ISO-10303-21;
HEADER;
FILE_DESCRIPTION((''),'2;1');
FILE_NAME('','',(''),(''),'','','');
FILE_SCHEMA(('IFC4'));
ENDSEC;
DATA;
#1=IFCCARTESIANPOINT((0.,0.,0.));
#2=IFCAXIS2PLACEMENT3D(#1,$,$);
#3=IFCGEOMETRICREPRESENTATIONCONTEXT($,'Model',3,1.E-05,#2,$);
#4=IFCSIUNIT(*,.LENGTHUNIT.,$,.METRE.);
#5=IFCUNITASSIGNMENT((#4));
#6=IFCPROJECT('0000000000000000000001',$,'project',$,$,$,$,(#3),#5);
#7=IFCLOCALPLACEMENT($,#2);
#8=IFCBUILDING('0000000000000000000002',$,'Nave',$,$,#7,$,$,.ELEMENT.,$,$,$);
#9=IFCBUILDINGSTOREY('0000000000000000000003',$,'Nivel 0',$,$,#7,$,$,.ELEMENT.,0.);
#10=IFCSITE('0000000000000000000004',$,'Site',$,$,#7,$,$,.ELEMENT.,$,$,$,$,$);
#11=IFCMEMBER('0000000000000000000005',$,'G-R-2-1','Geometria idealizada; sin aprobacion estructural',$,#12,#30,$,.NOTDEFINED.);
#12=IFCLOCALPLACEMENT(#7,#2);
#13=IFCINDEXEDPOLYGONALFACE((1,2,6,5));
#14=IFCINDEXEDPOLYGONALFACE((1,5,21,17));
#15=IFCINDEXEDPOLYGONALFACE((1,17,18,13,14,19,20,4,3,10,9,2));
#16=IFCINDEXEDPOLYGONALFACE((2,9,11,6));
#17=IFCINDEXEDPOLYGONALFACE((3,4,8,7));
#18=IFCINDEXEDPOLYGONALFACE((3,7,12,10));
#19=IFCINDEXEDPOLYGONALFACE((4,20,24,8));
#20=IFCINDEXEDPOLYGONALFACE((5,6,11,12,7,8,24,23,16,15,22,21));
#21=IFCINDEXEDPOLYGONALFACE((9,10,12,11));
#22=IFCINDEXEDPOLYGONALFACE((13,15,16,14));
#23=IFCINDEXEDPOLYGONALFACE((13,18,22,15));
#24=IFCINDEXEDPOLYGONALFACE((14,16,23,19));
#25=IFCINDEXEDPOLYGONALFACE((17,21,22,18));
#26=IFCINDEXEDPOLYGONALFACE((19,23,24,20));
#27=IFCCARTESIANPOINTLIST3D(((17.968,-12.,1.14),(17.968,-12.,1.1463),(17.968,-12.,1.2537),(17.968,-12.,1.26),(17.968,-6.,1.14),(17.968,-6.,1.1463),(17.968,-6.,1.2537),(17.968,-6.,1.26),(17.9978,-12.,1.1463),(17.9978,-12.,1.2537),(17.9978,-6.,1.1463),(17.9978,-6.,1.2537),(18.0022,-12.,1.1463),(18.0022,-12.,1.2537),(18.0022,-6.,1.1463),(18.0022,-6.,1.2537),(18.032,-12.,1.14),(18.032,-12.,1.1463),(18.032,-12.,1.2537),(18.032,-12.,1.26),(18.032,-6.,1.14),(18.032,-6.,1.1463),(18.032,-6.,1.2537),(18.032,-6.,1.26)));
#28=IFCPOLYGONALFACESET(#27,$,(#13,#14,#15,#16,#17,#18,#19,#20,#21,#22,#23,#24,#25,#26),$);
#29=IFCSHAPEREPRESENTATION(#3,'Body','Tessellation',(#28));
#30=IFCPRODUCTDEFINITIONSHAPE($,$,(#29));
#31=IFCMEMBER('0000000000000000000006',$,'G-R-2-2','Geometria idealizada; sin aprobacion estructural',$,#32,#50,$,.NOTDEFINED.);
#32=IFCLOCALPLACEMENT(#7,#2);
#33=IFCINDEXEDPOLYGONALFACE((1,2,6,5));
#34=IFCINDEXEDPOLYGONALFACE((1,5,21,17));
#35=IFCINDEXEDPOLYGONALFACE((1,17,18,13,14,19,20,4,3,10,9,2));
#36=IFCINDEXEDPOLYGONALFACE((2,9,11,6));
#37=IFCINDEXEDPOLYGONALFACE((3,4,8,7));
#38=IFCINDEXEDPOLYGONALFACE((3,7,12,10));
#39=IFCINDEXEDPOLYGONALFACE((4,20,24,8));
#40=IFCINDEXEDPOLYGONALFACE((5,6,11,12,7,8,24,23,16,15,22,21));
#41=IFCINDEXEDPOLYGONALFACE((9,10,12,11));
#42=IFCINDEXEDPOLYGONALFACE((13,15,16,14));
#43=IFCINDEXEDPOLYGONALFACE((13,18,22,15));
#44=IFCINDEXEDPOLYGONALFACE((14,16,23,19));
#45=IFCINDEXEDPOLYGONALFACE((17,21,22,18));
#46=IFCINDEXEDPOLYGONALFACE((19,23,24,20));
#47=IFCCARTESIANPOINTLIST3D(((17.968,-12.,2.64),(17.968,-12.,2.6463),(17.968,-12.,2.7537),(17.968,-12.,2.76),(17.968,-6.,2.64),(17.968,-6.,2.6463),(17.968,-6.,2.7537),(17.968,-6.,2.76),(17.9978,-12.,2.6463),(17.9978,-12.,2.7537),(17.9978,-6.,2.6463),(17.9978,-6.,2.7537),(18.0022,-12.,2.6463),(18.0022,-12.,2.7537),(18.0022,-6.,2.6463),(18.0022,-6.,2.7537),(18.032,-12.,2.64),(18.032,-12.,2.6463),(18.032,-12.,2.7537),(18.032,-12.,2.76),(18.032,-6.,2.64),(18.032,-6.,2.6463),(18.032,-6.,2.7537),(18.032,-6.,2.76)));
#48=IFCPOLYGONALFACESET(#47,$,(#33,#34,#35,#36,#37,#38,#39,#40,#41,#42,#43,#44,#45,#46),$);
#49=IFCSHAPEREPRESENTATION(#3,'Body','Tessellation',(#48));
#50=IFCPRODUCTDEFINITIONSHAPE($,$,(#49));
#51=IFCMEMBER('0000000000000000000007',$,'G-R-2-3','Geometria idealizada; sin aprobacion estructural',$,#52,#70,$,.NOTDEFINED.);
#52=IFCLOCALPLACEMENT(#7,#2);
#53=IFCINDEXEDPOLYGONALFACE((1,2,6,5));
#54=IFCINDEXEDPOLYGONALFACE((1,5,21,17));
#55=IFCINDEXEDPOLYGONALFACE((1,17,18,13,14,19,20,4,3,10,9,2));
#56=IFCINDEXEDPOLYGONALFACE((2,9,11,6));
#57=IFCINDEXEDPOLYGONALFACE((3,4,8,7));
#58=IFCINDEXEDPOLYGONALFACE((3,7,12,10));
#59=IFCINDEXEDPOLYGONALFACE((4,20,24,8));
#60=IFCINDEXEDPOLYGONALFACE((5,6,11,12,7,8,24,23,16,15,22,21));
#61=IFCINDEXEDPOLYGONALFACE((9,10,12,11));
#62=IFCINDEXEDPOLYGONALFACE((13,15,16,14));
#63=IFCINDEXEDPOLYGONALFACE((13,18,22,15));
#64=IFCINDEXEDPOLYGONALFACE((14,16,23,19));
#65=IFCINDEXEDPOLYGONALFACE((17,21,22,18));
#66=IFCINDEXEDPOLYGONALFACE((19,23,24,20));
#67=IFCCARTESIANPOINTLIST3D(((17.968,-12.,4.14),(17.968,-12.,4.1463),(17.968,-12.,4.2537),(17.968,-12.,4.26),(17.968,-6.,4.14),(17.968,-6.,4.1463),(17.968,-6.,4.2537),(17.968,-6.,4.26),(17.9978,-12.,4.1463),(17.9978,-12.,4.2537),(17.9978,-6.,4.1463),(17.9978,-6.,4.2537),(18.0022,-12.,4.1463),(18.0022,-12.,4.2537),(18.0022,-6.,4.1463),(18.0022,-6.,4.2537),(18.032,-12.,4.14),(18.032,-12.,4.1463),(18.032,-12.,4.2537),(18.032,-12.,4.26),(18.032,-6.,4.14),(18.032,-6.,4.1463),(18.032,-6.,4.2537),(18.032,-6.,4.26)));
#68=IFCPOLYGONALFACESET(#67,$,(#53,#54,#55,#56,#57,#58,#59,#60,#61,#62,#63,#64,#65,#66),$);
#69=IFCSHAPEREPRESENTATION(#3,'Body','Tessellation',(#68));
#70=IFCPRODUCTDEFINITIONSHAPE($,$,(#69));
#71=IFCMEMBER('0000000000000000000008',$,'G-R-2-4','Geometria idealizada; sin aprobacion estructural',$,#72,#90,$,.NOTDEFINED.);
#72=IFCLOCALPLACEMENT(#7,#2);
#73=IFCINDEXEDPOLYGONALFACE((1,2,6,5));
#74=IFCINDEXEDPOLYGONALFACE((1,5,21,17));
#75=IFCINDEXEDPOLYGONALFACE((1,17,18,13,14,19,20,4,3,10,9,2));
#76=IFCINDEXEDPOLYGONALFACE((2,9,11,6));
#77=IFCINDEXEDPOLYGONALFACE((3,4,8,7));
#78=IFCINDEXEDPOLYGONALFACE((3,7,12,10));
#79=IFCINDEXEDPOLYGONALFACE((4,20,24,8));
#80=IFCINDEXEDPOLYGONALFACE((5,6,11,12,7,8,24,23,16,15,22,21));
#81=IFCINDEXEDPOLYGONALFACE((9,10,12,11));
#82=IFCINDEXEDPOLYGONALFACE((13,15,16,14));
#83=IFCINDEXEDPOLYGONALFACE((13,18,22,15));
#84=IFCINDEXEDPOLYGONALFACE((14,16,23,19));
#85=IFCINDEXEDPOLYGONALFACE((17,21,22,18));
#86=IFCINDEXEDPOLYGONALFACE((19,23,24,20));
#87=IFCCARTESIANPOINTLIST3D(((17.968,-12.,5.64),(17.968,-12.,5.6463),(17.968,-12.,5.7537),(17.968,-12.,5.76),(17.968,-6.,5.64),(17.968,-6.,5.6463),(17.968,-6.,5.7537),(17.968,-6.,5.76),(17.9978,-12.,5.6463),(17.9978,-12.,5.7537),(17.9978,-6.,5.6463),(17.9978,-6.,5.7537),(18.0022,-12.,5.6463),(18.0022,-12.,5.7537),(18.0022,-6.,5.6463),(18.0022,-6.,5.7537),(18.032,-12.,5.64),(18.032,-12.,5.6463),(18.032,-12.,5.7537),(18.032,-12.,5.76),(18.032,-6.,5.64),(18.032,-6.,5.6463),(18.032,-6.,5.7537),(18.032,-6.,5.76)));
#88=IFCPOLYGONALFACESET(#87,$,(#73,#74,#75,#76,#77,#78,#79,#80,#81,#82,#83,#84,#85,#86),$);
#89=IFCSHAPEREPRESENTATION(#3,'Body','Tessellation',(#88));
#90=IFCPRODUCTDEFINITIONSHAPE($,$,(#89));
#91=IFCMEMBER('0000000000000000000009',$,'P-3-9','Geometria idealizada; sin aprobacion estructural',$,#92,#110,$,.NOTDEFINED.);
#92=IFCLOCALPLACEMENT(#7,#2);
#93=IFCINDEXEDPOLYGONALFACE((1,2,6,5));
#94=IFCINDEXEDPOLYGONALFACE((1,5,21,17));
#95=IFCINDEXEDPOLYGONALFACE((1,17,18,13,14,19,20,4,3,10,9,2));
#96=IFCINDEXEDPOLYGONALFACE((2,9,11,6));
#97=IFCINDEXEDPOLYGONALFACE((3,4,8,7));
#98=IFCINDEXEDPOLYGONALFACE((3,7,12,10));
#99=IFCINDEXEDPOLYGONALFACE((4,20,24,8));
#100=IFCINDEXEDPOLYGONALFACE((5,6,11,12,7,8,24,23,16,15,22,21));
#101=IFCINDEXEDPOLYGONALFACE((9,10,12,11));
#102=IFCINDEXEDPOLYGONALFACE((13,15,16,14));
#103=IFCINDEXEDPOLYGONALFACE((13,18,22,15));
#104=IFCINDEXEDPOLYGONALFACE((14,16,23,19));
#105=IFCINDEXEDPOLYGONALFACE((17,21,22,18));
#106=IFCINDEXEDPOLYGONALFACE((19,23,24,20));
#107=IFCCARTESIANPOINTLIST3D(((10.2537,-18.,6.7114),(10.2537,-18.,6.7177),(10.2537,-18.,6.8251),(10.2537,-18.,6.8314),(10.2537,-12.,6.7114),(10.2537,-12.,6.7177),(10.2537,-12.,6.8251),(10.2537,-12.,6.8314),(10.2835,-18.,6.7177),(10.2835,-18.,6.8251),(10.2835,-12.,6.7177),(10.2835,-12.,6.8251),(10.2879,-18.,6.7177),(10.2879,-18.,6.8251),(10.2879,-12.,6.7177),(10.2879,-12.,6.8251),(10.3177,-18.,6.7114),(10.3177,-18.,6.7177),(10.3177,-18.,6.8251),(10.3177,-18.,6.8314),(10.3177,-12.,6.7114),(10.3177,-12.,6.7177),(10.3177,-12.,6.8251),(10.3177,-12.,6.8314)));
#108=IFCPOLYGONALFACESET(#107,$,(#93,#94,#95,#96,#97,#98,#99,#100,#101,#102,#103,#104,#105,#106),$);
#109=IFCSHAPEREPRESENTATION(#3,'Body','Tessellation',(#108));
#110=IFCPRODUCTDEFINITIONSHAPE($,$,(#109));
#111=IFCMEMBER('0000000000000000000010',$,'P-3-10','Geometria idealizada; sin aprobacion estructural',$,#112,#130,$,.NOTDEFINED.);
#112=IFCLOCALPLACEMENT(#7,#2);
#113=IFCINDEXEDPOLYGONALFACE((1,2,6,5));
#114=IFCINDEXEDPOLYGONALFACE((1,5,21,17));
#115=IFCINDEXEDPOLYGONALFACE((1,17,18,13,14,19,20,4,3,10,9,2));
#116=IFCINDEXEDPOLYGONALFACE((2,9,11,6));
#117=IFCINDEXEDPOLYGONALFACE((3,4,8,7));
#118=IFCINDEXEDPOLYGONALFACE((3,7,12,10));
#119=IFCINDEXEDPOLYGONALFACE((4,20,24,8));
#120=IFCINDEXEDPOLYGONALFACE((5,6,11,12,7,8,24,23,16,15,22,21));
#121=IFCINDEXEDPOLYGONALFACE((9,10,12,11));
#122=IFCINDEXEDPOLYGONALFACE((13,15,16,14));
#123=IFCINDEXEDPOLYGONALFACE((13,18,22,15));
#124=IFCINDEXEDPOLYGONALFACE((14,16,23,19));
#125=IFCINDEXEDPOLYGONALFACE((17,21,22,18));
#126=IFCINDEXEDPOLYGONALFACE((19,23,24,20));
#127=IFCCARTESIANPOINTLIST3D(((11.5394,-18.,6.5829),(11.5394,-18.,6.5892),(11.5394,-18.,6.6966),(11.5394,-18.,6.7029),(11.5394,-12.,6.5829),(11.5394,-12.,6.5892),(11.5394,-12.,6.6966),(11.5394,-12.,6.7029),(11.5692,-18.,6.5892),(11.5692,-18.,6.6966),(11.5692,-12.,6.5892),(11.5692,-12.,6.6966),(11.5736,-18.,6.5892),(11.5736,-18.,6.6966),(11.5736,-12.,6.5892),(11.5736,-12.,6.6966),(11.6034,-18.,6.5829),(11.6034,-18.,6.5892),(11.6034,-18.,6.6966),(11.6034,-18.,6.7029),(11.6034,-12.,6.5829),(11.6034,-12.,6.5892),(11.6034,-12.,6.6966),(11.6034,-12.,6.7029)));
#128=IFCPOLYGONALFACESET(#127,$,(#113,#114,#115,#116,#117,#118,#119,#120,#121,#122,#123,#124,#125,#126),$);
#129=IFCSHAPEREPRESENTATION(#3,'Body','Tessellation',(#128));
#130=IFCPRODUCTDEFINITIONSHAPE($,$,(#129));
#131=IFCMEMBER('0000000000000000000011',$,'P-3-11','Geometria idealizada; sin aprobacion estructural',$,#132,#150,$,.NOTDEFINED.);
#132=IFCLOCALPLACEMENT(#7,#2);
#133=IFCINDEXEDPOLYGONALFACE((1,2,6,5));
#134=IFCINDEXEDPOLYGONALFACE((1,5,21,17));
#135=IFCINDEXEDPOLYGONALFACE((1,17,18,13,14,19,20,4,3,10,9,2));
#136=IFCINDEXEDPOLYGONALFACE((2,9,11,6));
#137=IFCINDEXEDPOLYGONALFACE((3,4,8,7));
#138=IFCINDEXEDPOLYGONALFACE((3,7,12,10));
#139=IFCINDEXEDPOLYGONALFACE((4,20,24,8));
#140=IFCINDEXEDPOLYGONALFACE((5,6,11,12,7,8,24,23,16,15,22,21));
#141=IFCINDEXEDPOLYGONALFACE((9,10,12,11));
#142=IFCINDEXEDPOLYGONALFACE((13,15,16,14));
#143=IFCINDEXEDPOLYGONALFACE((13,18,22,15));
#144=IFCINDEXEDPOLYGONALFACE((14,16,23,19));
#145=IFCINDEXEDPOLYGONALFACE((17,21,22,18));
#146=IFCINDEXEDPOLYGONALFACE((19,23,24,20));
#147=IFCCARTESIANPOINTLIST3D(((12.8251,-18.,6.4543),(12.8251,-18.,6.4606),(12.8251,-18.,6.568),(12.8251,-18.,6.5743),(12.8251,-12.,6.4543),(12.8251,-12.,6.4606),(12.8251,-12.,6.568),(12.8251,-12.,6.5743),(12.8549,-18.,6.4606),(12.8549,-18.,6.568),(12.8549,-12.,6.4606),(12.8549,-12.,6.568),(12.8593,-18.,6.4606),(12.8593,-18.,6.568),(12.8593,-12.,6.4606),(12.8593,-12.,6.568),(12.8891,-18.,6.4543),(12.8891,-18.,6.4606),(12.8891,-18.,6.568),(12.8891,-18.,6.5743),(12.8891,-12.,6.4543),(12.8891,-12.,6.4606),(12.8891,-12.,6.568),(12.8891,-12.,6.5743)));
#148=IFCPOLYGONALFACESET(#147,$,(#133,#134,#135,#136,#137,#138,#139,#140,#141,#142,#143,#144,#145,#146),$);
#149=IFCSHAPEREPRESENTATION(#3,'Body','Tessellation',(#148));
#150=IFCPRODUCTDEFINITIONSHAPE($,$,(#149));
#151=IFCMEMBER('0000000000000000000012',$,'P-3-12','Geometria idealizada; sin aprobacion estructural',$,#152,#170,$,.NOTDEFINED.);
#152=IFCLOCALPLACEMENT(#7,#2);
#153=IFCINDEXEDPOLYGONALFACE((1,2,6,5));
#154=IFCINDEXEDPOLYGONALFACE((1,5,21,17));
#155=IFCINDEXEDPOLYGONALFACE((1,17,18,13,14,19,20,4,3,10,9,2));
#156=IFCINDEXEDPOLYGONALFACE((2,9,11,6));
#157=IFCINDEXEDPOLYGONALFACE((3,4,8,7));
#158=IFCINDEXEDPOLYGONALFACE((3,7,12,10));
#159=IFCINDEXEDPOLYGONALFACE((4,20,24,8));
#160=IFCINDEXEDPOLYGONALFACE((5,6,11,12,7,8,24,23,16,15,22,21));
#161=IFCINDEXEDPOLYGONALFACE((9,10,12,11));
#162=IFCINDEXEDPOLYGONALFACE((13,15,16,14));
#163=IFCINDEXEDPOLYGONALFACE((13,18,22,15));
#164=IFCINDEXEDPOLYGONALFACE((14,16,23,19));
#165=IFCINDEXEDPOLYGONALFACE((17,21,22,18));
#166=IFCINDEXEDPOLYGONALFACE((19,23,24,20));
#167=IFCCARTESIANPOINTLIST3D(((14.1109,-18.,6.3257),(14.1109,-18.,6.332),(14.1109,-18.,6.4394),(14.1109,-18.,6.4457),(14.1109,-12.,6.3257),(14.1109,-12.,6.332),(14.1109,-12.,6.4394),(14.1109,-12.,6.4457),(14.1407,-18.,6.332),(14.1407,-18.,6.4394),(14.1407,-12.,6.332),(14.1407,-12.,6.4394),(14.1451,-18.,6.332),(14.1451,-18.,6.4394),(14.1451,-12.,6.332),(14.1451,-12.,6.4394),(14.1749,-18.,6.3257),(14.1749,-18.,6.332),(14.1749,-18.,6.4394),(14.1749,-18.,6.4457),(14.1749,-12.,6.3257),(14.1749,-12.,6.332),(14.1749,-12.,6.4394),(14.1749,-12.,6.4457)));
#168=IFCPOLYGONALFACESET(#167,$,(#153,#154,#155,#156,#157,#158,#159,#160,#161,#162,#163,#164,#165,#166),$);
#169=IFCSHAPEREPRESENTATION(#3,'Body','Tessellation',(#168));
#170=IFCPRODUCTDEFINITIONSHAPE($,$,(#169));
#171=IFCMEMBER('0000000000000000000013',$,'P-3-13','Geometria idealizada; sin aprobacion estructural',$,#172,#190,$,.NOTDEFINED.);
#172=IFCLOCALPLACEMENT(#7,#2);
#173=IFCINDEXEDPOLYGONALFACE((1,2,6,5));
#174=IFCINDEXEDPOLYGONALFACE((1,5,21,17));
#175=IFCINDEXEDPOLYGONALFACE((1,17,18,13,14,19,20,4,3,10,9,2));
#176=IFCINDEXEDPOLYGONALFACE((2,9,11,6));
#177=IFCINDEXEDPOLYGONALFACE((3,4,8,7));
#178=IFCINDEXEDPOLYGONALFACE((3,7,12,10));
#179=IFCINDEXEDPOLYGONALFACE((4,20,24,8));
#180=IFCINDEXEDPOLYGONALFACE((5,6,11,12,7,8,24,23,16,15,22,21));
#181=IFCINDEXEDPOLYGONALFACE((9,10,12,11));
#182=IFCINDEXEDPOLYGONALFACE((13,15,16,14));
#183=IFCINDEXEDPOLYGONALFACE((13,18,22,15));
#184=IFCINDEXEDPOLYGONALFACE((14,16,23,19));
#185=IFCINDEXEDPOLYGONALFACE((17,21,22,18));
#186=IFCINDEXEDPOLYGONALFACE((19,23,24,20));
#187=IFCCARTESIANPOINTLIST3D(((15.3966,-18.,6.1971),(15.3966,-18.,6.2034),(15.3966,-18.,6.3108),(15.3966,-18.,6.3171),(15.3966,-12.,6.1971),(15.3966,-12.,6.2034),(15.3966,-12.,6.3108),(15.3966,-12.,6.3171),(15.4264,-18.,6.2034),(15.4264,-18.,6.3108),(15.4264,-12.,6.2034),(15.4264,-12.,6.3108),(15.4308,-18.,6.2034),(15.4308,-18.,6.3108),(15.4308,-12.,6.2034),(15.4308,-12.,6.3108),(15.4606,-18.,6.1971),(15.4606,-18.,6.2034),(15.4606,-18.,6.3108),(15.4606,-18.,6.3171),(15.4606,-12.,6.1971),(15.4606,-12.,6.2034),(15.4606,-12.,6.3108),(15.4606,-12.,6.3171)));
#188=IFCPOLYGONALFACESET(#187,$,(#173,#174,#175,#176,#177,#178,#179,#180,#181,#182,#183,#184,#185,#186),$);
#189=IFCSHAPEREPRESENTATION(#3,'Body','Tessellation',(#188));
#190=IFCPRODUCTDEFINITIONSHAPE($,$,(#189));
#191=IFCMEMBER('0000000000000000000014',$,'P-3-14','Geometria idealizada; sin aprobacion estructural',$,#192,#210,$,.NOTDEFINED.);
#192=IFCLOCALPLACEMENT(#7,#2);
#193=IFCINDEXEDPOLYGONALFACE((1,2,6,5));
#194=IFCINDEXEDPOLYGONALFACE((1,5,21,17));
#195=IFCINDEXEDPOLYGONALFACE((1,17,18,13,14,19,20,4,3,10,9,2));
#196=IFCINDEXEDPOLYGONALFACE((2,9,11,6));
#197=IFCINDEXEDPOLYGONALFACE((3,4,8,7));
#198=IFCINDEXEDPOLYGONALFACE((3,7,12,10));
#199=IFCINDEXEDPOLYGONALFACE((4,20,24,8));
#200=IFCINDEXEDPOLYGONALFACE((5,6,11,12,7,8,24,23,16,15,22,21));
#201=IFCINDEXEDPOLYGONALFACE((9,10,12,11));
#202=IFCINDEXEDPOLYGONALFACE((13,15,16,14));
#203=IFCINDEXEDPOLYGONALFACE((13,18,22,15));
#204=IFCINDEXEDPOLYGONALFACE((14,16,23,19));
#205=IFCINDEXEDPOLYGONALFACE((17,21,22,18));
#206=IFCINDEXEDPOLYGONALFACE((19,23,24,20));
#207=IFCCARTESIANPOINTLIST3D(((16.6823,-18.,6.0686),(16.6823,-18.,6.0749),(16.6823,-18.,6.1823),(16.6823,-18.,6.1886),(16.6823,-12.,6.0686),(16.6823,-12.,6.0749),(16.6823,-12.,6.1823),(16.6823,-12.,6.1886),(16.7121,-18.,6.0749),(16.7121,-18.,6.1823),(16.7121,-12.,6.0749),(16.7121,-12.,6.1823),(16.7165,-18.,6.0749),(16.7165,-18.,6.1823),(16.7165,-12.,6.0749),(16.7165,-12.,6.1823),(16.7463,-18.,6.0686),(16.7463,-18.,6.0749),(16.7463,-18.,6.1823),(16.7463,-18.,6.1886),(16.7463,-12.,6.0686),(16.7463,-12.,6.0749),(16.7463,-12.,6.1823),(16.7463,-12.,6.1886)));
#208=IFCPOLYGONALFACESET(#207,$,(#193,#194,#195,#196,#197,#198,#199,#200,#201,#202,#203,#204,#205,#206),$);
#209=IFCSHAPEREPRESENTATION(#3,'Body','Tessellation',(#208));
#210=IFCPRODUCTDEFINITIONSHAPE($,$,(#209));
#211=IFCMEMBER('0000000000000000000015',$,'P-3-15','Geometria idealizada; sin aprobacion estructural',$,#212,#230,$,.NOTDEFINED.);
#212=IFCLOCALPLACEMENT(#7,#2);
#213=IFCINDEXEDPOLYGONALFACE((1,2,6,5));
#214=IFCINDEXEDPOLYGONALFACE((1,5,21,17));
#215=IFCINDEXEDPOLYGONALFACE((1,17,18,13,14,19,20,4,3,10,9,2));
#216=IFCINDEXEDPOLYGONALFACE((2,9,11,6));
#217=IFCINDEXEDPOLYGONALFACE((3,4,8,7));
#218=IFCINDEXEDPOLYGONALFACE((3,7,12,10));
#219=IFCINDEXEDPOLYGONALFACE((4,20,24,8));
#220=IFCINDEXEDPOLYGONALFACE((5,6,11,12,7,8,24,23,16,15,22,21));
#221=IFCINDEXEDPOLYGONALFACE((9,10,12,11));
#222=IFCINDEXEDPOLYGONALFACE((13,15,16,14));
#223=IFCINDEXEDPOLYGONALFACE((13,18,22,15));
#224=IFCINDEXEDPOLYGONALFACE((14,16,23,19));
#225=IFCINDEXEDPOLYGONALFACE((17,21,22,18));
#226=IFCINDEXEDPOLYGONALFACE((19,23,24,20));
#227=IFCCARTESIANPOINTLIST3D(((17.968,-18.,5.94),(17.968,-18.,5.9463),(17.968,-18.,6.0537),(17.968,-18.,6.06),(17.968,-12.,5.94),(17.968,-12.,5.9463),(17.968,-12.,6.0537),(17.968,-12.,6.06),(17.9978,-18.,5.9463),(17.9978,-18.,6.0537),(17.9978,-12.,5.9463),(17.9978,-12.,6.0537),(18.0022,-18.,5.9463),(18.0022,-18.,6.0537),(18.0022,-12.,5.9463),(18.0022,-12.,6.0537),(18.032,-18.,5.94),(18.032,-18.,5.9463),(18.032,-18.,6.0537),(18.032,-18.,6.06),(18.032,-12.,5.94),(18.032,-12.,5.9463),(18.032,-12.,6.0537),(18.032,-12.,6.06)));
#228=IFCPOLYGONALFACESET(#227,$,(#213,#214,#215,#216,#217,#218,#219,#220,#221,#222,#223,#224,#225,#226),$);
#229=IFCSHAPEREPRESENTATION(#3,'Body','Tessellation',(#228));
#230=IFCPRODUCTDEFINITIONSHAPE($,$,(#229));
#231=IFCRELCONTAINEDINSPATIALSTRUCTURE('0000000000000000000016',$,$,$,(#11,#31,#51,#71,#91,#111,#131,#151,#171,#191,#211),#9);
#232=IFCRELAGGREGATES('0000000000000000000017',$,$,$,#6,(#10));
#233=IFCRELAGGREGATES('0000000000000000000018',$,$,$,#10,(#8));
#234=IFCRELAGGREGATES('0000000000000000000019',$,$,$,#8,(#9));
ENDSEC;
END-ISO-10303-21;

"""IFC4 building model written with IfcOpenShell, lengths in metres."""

from ifc_helpers import new_model, si_unit, frame, origin, place, context, project, spatial, polyline, outline, extrude, element, save


model = new_model("IFC4")

# Units and contexts
model_context = context("Model", 3, precision=1e-05, world=origin())
ifc_project = project(units=[si_unit("LENGTHUNIT", "METRE")], contexts=[model_context])

# Site, building, storey
placement = place(None, origin())
site = spatial("IfcSite", under=ifc_project, at=placement, Name="Site", CompositionType="ELEMENT")
building = spatial("IfcBuilding", under=site, at=placement, Name="Nave", CompositionType="ELEMENT")
storey = spatial("IfcBuildingStorey", under=building, at=placement, Name="Nivel 0", CompositionType="ELEMENT", Elevation=0.0)

# Members
for number, where, z_axis, x_axis, name in (
    (1, (18.0, -6.0, 1.2), (0.0, -1.0, 0.0), (1.0, 0.0, 0.0), "G-R-2-1"),
    (2, (18.0, -6.0, 2.7), (0.0, -1.0, 0.0), (1.0, 0.0, 0.0), "G-R-2-2"),
    (3, (18.0, -6.0, 4.2), (0.0, -1.0, 0.0), (1.0, 0.0, 0.0), "G-R-2-3"),
    (4, (18.0, -6.0, 5.7), (0.0, -1.0, 0.0), (1.0, 0.0, 0.0), "G-R-2-4"),
    (5, (10.2857, -12.0, 6.7714), (0.0, -1.0, 0.0), (1.0, 0.0, 0.0), "P-3-9"),
    (6, (11.5714, -12.0, 6.6429), (0.0, -1.0, 0.0), (1.0, 0.0, 0.0), "P-3-10"),
    (7, (12.8571, -12.0, 6.5143), (0.0, -1.0, 0.0), (1.0, 0.0, 0.0), "P-3-11"),
    (8, (14.1429, -12.0, 6.3857), (0.0, -1.0, 0.0), (1.0, 0.0, 0.0), "P-3-12"),
    (9, (15.4286, -12.0, 6.2571), (0.0, -1.0, 0.0), (1.0, 0.0, 0.0), "P-3-13"),
    (10, (16.7143, -12.0, 6.1286), (0.0, -1.0, 0.0), (1.0, 0.0, 0.0), "P-3-14"),
    (11, (18.0, -12.0, 6.0), (0.0, -1.0, 0.0), (1.0, 0.0, 0.0), "P-3-15"),
):
    element("IfcMember", number, at=place(placement, frame(where, z_axis=z_axis, x_axis=x_axis)), inside=storey, Name=name, Description="Geometria idealizada; sin aprobacion estructural", PredefinedType="NOTDEFINED", context=model_context, shape_type="SweptSolid", body=[
        extrude(outline(polyline([(-0.032, -0.06), (0.032, -0.06), (0.032, -0.0537), (0.0022, -0.0537), (0.0022, 0.0537), (0.032, 0.0537), (0.032, 0.06), (-0.032, 0.06), (-0.032, 0.0537), (-0.0022, 0.0537), (-0.0022, -0.0537), (-0.032, -0.0537), (-0.032, -0.06)])), origin(), (0.0, 0.0, 1.0), 6.0),
    ])

save(model, "model.ifc")
